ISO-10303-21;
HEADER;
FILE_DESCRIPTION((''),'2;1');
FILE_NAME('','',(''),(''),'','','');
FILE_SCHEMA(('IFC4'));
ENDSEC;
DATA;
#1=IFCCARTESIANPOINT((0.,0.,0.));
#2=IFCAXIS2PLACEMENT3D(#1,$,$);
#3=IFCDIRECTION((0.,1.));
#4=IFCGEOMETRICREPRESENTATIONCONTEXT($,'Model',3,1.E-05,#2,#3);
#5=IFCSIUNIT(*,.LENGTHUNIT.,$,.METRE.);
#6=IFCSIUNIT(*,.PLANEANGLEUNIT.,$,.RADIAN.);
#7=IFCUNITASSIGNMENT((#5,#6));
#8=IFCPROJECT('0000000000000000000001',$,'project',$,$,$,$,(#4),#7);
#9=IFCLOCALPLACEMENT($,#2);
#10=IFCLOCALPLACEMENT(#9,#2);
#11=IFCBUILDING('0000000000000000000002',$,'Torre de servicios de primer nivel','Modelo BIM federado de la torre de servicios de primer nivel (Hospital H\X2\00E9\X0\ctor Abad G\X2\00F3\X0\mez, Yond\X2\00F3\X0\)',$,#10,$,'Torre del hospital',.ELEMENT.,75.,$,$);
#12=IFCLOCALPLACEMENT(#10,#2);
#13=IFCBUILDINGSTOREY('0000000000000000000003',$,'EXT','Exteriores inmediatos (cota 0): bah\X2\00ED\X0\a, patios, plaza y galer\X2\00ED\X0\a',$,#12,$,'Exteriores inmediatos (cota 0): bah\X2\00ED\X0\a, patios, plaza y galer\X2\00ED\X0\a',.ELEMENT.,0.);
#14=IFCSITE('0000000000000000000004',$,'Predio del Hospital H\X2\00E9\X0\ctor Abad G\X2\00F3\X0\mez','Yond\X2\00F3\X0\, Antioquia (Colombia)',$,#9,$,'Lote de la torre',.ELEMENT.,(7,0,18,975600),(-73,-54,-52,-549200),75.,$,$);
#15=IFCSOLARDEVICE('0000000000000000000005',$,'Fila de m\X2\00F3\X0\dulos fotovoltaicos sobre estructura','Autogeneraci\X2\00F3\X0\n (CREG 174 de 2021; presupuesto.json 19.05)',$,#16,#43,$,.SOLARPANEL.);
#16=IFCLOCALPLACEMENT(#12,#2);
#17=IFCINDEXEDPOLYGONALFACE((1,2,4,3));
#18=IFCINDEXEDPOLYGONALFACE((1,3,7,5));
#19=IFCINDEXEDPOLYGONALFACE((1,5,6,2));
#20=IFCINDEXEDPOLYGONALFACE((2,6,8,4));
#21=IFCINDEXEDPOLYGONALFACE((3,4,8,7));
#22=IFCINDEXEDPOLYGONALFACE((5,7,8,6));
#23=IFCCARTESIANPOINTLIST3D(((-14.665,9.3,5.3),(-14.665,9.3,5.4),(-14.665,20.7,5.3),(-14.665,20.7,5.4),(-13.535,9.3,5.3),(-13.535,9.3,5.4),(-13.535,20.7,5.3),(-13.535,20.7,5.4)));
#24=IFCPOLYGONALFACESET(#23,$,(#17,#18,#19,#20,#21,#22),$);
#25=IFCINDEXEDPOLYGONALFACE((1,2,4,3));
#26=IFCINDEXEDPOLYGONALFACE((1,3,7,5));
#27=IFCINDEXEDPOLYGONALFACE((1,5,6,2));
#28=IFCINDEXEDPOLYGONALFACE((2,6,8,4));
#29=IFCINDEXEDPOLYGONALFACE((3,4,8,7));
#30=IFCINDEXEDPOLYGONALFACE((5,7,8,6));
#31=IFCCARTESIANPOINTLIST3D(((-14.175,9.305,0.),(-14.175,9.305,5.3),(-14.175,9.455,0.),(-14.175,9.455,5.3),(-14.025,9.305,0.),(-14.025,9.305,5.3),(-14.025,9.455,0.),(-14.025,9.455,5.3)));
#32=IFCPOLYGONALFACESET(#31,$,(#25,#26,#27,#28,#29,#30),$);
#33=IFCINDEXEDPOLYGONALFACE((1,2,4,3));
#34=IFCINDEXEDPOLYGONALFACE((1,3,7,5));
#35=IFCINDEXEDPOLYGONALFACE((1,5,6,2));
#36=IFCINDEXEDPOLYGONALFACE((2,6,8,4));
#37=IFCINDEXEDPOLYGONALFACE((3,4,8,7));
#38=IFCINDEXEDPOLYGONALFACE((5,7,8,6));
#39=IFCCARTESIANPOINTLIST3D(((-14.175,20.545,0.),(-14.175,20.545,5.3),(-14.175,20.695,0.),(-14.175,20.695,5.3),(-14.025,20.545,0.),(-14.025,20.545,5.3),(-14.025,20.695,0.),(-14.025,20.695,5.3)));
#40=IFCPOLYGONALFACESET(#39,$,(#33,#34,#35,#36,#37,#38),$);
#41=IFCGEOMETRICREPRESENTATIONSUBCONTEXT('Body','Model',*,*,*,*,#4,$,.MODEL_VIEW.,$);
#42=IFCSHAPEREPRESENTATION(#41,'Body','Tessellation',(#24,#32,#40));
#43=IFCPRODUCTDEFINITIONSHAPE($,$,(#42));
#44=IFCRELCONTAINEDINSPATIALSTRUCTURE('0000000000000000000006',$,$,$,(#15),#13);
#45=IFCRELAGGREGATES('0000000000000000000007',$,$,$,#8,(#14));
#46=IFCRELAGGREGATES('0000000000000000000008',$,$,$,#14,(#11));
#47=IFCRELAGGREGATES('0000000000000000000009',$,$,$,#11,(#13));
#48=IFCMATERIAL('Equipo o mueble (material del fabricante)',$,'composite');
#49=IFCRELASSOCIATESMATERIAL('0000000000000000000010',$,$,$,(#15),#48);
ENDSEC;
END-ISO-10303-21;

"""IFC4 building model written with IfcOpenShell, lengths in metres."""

from ifc_helpers import new_model, si_unit, direction, frame, origin, place, context, subcontext, project, spatial, rectangle, extrude, material, element, save


model = new_model("IFC4")

# Units and contexts
model_context = context("Model", 3, precision=1e-05, world=origin(), true_north=direction((0.0, 1.0)))
body_context = subcontext(model_context, "Body", "Model", "MODEL_VIEW")
ifc_project = project(units=[si_unit("LENGTHUNIT", "METRE"), si_unit("PLANEANGLEUNIT", "RADIAN")], contexts=[model_context])

# Site, building, storey
site_placement = place(None, origin())
site = spatial("IfcSite", under=ifc_project, at=site_placement, Name="Predio del Hospital Héctor Abad Gómez", Description="Yondó, Antioquia (Colombia)", LongName="Lote de la torre", CompositionType="ELEMENT", RefLatitude=(7, 0, 18, 975600), RefLongitude=(-73, -54, -52, -549200), RefElevation=75.0)
building_placement = place(site_placement, origin())
building = spatial("IfcBuilding", under=site, at=building_placement, Name="Torre de servicios de primer nivel", Description="Modelo BIM federado de la torre de servicios de primer nivel (Hospital Héctor Abad Gómez, Yondó)", LongName="Torre del hospital", CompositionType="ELEMENT", ElevationOfRefHeight=75.0)
placement = place(building_placement, origin())
storey = spatial("IfcBuildingStorey", under=building, at=placement, Name="EXT", Description="Exteriores inmediatos (cota 0): bahía, patios, plaza y galería", LongName="Exteriores inmediatos (cota 0): bahía, patios, plaza y galería", CompositionType="ELEMENT", Elevation=0.0)

# Solar device
ifc_material_1 = material(Name="Equipo o mueble (material del fabricante)", Category="composite")
element("IfcSolarDevice", 1, at=placement, inside=storey, material=ifc_material_1, Name="Fila de módulos fotovoltaicos sobre estructura", Description="Autogeneración (CREG 174 de 2021; presupuesto.json 19.05)", PredefinedType="SOLARPANEL", context=body_context, shape_type="SweptSolid", body=[
    extrude(rectangle(XDim=11.4, YDim=1.13), frame((-14.1, 15.0, 5.3), z_axis=(0.0, 0.0, 1.0), x_axis=(0.0, 1.0, 0.0)), (0.0, 0.0, 1.0), 0.1),
    extrude(rectangle(XDim=0.15, YDim=0.15), frame((-14.1, 9.38, 0.0), z_axis=(0.0, 0.0, 1.0), x_axis=(0.0, 1.0, 0.0)), (0.0, 0.0, 1.0), 5.3),
    extrude(rectangle(XDim=0.15, YDim=0.15), frame((-14.1, 20.62, 0.0), z_axis=(0.0, 0.0, 1.0), x_axis=(0.0, 1.0, 0.0)), (0.0, 0.0, 1.0), 5.3),
])

save(model, "model.ifc")
